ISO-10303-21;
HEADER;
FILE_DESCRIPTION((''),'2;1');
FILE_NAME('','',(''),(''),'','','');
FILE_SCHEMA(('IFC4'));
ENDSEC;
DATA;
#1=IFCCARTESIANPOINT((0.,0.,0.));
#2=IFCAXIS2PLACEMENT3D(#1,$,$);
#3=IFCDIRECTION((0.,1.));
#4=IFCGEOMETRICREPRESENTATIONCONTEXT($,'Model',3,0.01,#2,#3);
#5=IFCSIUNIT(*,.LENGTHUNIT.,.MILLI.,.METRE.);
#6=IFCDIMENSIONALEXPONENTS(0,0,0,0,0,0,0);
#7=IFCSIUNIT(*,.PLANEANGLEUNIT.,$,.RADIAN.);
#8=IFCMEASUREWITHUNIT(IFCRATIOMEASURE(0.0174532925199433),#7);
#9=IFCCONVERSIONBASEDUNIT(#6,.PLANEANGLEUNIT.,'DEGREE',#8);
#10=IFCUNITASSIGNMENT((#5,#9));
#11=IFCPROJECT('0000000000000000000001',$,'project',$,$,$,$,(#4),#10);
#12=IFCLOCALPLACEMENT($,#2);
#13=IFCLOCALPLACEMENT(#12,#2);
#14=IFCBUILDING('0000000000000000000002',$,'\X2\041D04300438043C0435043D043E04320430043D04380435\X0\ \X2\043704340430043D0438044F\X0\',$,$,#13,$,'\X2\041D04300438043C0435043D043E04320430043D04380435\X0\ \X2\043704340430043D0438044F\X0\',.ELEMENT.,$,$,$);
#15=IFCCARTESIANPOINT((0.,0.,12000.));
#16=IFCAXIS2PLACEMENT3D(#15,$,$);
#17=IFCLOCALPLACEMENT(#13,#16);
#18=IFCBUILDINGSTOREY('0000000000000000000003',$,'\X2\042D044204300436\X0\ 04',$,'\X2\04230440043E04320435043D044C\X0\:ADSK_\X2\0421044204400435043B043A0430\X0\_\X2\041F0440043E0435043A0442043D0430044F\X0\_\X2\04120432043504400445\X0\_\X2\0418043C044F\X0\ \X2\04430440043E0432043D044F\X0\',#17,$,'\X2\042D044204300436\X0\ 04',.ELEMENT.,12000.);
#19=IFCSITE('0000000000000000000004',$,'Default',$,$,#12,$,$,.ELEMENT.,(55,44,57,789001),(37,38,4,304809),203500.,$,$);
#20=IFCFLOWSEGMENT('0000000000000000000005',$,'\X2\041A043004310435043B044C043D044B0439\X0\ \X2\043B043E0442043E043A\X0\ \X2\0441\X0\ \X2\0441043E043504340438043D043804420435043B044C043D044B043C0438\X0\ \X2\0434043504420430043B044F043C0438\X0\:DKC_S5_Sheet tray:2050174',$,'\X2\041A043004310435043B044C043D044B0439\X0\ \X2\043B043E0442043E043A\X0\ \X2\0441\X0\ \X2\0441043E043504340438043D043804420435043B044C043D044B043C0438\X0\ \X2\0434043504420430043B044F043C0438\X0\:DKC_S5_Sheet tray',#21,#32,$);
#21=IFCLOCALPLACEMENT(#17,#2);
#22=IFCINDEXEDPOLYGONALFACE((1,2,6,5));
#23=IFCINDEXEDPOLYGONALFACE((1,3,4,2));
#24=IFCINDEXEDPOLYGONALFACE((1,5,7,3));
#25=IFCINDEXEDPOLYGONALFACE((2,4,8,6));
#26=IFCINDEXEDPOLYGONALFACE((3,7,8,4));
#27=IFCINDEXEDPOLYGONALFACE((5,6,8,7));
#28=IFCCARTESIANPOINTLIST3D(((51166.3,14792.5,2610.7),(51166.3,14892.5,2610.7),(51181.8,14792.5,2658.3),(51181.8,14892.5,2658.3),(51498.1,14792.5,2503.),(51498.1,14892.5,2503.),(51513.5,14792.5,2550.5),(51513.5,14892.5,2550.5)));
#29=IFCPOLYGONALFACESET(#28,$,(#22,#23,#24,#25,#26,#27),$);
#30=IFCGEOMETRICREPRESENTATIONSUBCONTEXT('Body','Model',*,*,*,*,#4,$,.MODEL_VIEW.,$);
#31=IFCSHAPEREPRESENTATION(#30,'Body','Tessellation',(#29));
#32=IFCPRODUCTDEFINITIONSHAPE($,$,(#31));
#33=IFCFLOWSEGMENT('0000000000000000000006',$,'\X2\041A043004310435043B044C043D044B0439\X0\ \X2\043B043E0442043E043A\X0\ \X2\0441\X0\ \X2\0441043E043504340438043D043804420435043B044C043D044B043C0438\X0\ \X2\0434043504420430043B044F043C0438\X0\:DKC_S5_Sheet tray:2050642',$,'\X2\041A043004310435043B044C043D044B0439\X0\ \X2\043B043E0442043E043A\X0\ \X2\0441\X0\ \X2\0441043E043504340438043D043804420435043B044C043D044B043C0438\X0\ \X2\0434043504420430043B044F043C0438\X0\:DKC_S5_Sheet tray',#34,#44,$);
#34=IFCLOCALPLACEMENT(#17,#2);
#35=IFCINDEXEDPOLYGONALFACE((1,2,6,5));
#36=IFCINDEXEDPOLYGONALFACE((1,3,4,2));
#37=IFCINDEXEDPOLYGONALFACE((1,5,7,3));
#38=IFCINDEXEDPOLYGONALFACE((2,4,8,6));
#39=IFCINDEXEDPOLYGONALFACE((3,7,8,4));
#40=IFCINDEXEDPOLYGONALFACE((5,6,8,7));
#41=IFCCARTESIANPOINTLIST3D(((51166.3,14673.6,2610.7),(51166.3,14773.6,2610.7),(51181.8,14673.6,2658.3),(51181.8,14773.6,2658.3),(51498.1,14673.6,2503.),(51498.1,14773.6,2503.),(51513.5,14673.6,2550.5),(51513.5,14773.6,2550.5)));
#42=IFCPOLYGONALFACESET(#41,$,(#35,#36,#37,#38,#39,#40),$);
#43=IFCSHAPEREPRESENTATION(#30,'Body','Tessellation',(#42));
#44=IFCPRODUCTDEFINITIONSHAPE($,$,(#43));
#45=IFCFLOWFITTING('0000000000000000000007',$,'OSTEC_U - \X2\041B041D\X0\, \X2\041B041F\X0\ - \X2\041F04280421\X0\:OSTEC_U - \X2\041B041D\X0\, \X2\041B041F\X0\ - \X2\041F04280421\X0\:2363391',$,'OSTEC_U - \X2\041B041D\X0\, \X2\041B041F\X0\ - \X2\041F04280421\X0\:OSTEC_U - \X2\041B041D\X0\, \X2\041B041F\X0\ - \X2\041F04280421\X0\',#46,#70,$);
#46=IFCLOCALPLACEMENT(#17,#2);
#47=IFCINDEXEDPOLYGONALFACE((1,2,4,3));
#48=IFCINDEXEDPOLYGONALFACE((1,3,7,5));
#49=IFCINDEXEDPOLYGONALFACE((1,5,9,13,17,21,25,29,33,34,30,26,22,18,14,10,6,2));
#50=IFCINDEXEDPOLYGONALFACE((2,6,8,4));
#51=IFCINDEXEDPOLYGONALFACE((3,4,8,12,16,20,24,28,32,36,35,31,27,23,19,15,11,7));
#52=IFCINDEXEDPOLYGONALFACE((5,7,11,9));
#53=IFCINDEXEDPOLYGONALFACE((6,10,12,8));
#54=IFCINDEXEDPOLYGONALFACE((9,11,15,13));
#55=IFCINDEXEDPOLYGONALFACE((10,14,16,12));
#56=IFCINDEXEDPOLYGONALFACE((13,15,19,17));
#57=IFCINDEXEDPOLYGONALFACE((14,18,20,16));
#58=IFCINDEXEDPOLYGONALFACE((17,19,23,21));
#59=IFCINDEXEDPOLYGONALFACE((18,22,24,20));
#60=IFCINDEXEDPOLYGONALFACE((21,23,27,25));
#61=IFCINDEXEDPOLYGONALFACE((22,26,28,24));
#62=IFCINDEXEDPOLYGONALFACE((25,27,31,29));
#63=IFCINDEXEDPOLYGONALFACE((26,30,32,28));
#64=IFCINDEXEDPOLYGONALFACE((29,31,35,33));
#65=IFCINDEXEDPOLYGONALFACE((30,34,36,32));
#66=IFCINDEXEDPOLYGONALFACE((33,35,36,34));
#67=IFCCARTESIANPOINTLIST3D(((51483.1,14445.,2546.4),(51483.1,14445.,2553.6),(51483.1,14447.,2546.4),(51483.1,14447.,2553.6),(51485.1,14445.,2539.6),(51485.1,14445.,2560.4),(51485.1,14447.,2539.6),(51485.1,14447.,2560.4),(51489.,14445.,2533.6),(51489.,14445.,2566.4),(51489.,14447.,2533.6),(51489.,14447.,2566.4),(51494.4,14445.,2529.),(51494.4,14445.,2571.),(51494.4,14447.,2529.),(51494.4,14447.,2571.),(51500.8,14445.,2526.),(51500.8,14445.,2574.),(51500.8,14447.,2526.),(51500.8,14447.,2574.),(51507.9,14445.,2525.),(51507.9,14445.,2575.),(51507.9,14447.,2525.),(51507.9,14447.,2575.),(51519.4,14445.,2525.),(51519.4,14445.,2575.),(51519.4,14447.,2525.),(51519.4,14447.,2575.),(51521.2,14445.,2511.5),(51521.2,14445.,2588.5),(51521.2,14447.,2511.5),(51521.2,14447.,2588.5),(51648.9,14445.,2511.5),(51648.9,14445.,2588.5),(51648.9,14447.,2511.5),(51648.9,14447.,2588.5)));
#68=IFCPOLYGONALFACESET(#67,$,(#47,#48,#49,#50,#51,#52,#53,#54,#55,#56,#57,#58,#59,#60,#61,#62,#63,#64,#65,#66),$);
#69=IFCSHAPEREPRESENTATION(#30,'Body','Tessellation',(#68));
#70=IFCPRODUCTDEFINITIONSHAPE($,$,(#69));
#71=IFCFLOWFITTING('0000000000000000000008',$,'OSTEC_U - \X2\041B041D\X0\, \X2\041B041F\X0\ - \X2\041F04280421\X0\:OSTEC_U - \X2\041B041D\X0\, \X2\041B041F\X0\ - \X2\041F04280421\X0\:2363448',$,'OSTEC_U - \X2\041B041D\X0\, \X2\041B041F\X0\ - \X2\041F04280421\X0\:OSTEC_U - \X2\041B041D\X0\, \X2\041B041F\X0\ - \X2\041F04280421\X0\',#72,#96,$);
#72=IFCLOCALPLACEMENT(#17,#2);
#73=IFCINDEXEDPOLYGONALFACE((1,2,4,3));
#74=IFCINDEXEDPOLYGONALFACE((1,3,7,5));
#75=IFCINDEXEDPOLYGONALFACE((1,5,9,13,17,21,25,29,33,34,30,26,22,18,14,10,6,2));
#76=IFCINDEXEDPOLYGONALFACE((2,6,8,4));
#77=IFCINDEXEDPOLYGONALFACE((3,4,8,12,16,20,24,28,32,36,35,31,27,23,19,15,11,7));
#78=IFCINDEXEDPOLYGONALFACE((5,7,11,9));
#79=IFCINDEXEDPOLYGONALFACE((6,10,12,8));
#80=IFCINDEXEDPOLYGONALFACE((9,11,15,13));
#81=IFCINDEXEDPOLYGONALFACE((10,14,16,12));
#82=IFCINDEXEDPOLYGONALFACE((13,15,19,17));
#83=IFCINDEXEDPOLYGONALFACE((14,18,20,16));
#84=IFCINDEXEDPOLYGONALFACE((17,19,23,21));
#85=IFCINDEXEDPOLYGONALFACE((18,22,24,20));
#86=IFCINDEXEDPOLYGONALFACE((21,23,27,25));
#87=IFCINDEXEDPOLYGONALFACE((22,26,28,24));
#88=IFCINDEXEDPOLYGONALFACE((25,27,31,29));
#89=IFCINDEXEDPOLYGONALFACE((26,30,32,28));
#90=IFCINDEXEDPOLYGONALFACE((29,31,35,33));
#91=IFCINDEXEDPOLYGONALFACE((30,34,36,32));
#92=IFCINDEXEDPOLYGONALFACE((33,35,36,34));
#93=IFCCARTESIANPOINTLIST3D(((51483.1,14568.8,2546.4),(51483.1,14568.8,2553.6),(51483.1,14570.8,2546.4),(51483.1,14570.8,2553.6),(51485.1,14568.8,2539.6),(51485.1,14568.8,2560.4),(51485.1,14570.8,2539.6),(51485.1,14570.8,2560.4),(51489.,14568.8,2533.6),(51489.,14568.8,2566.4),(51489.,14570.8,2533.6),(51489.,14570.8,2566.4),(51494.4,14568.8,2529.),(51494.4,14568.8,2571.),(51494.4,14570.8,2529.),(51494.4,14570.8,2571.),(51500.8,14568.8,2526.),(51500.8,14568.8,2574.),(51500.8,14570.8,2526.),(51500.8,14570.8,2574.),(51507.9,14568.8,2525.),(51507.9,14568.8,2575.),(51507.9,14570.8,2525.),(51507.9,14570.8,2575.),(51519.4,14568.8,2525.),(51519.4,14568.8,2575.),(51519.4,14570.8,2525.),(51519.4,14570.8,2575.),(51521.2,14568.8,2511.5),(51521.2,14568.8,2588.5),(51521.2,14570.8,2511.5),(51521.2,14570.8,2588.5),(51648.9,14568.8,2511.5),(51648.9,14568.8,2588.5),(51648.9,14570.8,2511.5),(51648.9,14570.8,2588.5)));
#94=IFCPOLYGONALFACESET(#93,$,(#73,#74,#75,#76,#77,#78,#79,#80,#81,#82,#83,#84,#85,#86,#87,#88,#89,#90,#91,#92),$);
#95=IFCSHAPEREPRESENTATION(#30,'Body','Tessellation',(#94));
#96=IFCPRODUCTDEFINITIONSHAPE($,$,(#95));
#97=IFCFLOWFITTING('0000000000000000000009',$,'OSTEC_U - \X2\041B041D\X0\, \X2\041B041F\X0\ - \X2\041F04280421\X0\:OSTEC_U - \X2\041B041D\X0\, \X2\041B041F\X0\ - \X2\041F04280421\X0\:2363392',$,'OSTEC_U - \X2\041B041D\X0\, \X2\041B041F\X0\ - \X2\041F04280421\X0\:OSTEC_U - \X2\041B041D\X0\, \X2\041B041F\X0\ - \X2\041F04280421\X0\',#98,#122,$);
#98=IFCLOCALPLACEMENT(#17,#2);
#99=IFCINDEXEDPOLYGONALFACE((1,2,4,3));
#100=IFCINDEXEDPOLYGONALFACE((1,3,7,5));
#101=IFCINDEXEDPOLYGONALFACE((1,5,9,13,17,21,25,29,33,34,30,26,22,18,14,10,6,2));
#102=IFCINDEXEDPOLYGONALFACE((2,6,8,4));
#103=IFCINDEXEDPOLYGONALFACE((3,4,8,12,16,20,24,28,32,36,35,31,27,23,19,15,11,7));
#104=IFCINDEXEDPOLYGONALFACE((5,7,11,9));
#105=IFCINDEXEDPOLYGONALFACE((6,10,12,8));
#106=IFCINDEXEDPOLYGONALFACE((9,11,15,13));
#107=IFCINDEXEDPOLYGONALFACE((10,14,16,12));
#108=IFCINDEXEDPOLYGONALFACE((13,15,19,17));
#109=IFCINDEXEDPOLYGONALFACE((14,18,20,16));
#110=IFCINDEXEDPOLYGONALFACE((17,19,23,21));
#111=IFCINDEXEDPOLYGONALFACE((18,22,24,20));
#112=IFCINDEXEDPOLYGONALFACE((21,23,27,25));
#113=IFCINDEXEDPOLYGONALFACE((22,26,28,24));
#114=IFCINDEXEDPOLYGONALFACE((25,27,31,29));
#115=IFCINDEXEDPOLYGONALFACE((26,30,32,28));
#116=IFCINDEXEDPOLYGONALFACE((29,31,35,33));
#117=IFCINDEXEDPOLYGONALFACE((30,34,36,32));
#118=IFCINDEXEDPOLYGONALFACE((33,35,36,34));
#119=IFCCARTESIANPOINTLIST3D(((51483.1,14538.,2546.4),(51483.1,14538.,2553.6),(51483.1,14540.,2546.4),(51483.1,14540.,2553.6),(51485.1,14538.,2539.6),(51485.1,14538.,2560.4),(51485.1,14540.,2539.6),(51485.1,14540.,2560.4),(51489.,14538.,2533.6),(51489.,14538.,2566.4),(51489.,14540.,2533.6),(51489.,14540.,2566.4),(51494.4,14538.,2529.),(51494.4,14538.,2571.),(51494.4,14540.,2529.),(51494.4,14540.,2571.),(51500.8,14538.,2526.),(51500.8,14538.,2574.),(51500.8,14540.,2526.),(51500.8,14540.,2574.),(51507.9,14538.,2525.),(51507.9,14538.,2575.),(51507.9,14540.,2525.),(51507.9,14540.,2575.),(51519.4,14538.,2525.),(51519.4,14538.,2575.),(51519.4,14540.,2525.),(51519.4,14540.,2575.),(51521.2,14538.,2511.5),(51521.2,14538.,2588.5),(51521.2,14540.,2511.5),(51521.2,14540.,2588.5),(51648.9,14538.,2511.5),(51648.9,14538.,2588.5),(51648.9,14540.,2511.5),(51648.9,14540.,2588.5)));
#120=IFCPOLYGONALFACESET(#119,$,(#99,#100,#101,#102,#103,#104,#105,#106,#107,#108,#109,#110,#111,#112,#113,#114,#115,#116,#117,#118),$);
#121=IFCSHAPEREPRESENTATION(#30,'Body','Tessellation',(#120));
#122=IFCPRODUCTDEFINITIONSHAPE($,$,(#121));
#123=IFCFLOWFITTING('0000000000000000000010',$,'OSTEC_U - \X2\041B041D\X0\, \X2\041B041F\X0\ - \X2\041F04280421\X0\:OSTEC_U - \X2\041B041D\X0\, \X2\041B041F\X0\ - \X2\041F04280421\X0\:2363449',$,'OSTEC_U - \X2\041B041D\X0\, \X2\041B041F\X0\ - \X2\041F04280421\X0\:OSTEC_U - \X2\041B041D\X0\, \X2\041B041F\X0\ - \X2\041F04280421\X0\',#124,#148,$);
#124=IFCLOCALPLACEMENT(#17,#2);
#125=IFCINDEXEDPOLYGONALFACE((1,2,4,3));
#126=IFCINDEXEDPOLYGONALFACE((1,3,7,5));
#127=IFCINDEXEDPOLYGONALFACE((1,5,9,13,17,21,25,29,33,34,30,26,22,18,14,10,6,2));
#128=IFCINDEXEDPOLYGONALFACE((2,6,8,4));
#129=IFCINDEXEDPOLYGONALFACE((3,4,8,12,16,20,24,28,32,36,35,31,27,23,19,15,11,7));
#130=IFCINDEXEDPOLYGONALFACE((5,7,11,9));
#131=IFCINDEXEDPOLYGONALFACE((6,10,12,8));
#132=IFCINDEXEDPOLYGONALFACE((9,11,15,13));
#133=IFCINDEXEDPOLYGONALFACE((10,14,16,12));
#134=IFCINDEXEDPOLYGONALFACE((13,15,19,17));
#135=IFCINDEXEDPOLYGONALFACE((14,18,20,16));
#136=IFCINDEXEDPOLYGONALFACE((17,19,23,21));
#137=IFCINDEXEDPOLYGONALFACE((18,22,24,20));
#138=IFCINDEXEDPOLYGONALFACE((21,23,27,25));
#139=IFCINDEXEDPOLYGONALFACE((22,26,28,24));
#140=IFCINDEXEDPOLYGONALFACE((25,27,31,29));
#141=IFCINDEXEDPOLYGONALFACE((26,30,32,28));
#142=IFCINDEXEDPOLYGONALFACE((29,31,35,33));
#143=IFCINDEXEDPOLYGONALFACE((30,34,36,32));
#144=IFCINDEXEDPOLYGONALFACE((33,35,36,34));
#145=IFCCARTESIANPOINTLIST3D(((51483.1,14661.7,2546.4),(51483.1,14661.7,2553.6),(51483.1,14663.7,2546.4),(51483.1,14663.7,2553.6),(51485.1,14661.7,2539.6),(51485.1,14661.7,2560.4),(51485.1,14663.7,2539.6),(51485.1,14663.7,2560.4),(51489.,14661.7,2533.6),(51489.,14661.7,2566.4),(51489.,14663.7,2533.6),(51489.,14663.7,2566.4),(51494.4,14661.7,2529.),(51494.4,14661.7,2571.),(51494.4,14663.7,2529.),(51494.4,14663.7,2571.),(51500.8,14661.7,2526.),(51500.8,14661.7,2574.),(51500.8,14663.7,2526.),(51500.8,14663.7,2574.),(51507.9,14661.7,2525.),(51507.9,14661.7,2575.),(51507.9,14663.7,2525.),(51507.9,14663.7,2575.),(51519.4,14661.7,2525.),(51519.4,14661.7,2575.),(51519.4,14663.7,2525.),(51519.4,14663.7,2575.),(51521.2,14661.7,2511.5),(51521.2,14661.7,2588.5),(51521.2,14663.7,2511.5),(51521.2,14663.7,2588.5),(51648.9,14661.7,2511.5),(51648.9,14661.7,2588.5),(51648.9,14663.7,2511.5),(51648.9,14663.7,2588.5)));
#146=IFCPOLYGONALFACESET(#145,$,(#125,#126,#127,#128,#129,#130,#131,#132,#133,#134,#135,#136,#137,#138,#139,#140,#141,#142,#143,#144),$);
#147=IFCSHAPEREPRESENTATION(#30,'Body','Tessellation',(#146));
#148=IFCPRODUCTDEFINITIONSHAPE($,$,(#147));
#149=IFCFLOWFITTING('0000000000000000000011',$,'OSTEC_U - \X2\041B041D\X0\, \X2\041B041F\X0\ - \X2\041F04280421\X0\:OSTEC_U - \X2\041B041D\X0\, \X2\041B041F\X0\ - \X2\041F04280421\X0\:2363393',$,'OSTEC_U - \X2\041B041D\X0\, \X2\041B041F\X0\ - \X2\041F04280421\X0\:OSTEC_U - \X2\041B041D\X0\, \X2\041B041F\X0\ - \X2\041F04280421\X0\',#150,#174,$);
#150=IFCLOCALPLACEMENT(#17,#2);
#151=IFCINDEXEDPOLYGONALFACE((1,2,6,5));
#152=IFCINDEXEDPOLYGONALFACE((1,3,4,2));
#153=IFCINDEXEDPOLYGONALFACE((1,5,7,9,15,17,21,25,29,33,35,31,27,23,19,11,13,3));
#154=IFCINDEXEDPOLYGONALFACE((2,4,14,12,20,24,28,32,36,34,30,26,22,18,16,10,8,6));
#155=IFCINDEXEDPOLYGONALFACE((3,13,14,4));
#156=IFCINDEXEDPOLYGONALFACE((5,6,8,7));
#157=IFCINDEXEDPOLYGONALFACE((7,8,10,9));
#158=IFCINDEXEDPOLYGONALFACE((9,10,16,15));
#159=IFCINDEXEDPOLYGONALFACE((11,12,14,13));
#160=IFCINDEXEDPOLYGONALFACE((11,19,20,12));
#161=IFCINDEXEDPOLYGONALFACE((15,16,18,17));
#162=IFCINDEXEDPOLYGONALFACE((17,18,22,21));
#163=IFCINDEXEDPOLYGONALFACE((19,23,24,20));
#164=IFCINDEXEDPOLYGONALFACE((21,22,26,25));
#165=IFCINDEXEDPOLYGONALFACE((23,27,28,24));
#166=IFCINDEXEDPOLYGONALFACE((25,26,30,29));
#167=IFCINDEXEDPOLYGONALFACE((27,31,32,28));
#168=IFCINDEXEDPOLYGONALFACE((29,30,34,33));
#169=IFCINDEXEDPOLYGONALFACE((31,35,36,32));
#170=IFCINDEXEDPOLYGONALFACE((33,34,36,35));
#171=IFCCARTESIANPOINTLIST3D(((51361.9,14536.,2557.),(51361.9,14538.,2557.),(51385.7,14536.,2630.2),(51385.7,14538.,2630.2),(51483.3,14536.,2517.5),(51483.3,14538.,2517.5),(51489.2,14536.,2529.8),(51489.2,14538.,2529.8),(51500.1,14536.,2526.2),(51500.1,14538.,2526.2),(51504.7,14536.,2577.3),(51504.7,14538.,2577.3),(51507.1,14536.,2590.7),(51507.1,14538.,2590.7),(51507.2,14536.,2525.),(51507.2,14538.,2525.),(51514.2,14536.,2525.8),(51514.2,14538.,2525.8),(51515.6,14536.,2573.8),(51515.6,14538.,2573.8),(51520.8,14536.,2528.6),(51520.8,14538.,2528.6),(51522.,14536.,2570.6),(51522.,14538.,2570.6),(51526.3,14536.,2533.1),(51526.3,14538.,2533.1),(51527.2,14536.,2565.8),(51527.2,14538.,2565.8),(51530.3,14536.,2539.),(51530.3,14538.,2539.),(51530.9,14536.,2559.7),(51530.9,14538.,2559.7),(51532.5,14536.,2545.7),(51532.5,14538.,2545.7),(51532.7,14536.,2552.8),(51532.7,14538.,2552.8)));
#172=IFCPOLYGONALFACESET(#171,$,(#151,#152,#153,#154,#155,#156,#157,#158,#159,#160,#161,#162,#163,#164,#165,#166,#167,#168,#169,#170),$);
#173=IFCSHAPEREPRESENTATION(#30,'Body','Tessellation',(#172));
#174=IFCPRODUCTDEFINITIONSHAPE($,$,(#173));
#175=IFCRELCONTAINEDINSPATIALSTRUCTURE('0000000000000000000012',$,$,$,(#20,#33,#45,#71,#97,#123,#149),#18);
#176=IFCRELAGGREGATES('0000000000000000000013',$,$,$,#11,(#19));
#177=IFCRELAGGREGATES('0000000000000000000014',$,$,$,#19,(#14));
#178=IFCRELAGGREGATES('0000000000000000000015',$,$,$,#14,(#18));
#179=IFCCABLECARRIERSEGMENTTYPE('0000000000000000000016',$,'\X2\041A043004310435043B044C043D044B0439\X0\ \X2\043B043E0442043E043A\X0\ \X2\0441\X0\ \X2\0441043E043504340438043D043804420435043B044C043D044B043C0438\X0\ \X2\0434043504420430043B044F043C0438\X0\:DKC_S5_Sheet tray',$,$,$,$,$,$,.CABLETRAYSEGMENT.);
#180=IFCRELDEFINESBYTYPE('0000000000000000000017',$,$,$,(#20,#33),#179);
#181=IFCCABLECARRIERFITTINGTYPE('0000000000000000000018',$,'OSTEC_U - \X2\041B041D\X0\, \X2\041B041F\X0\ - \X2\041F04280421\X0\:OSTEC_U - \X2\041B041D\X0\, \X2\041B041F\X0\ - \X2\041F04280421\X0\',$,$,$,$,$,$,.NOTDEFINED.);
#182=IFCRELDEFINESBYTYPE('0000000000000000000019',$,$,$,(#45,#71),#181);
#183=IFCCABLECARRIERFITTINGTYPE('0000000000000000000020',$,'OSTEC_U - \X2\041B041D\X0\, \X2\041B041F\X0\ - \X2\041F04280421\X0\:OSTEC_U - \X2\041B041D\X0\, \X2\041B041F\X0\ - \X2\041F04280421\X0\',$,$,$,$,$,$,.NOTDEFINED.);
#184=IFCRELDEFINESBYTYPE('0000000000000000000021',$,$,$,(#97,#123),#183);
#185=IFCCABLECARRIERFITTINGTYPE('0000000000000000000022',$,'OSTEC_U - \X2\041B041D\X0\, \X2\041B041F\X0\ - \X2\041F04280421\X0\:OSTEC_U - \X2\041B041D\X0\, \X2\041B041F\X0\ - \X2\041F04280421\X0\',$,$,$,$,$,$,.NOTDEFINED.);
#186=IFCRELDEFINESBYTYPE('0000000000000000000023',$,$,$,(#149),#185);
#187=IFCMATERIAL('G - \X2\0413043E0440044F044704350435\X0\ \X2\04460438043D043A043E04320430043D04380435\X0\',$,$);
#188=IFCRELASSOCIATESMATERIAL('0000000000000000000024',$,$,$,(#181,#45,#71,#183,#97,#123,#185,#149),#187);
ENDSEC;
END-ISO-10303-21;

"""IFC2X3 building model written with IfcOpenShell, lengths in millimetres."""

from ifc_helpers import new_model, entity, si_unit, converted_unit, direction, frame, frame_2d, origin, origin_2d_with_axis, place, context, subcontext, project, spatial, polyline, circle_curve, parameter, trimmed, segment, composite_curve, rectangle, outline, extrude, source, transform, mapped, material, type_object, type_shapes, element, save


model = new_model("IFC2X3")

# Units and contexts
model_context = context("Model", 3, precision=0.01, world=origin(), true_north=direction((0.0, 1.0)))
body_context = subcontext(model_context, "Body", "Model", "MODEL_VIEW")
ifc_project = project(units=[si_unit("LENGTHUNIT", "METRE", prefix="MILLI"), converted_unit("PLANEANGLEUNIT", "DEGREE", entity("IfcRatioMeasure", 0.0174532925199433), si_unit("PLANEANGLEUNIT", "RADIAN"), dimensions=[0, 0, 0, 0, 0, 0, 0])], contexts=[model_context])

# Site, building, storey
site_placement = place(None, frame((0.0, 0.0, 0.0)))
site = spatial("IfcSite", under=ifc_project, at=site_placement, Name="Default", CompositionType="ELEMENT", RefLatitude=(55, 44, 57, 789001), RefLongitude=(37, 38, 4, 304809), RefElevation=203500.0)
building_placement = place(site_placement, origin())
building = spatial("IfcBuilding", under=site, at=building_placement, Name="Наименование здания", LongName="Наименование здания", CompositionType="ELEMENT")
storey_placement = place(building_placement, frame((0.0, 0.0, 12000.0)))
storey = spatial("IfcBuildingStorey", under=building, at=storey_placement, Name="Этаж 04", ObjectType="Уровень:ADSK_Стрелка_Проектная_Вверх_Имя уровня", LongName="Этаж 04", CompositionType="ELEMENT", Elevation=12000.0)

# Flow segments
cable_carrier_segment_type = type_object("IfcCableCarrierSegmentType", Name="Кабельный лоток с соединительными деталями:DKC_S5_Sheet tray", PredefinedType="CABLETRAYSEGMENT")
flow_segment_1_placement = place(storey_placement, frame((51166.3, 14792.5, 2503.0)))
element("IfcFlowSegment", 1, at=flow_segment_1_placement, inside=storey, type_object=cable_carrier_segment_type, Name="Кабельный лоток с соединительными деталями:DKC_S5_Sheet tray:2050174", ObjectType="Кабельный лоток с соединительными деталями:DKC_S5_Sheet tray", context=body_context, shape_type="SweptSolid", body=[
    extrude(rectangle(XDim=50.0, YDim=100.0, at=origin_2d_with_axis()), frame((7.7, 50.0, 131.6), z_axis=(0.951057, 0.0, -0.309017), x_axis=(0.309017, 0.0, 0.951057)), (0.0, 0.0, 1.0), 348.8),
])
flow_segment_2_placement = place(storey_placement, frame((51166.3, 14673.6, 2503.0)))
element("IfcFlowSegment", 2, at=flow_segment_2_placement, inside=storey, type_object=cable_carrier_segment_type, Name="Кабельный лоток с соединительными деталями:DKC_S5_Sheet tray:2050642", ObjectType="Кабельный лоток с соединительными деталями:DKC_S5_Sheet tray", context=body_context, shape_type="SweptSolid", body=[
    extrude(rectangle(XDim=50.0, YDim=100.0, at=frame_2d((0.0, 0.0), x_axis=(1.0, 0.0))), frame((7.7, 50.0, 131.6), z_axis=(0.951057, 0.0, -0.309017), x_axis=(0.309017, 0.0, 0.951057)), (0.0, 0.0, 1.0), 348.8),
])

# Flow fittings
ifc_material = material(Name="G - Горячее цинкование")
cable_carrier_fitting_type_1 = type_object("IfcCableCarrierFittingType", Name="OSTEC_U - ЛН, ЛП - ПШС:OSTEC_U - ЛН, ЛП - ПШС", PredefinedType="NOTDEFINED", material=ifc_material)
shared_shape_1 = source(origin(), body_context, "Body", "SweptSolid", [
    extrude(outline(composite_curve([segment(trimmed(circle_curve(frame_2d((-41.5, 0.0), x_axis=(1.0, 0.0)), 25.0), [parameter(90.0)], [parameter(270.0)], True, "PARAMETER"), True, "CONTINUOUS"), segment(polyline([(-41.5, -25.0), (-30.0, -25.0)]), True, "CONTINUOUS"), segment(polyline([(-30.0, -25.0), (-28.1, -38.5)]), True, "CONTINUOUS"), segment(polyline([(-28.1, -38.5), (99.5, -38.5)]), True, "CONTINUOUS"), segment(polyline([(99.5, -38.5), (99.5, 38.5)]), True, "CONTINUOUS"), segment(polyline([(99.5, 38.5), (-28.1, 38.5)]), True, "CONTINUOUS"), segment(polyline([(-28.1, 38.5), (-30.0, 25.0)]), True, "CONTINUOUS"), segment(polyline([(-30.0, 25.0), (-41.5, 25.0)]), True, "CONTINUOUS")], self_intersect=False)), frame((41.5, 0.0, 0.0), z_axis=(0.0, 0.0, -1.0), x_axis=(1.0, 0.0, 0.0)), (0.0, 0.0, -1.0), 2.0),
])
type_shapes(cable_carrier_fitting_type_1, [shared_shape_1])
for number, where, z_axis, x_axis, name in (
    (3, (51507.9, 14447.0, 2550.0), (0.0, -1.0, 0.0), (1.0, 0.0, 0.0), "OSTEC_U - ЛН, ЛП - ПШС:OSTEC_U - ЛН, ЛП - ПШС:2363391"),
    (4, (51507.9, 14570.8, 2550.0), (0.0, -1.0, 0.0), (1.0, 0.0, 0.0), "OSTEC_U - ЛН, ЛП - ПШС:OSTEC_U - ЛН, ЛП - ПШС:2363448"),
):
    element("IfcFlowFitting", number, at=place(storey_placement, frame(where, z_axis=z_axis, x_axis=x_axis)), inside=storey, type_object=cable_carrier_fitting_type_1, material=ifc_material, Name=name, ObjectType="OSTEC_U - ЛН, ЛП - ПШС:OSTEC_U - ЛН, ЛП - ПШС", context=body_context, shape_type="MappedRepresentation", body=[
        mapped(shared_shape_1, transform((0.0, 0.0, 0.0), scale=1.0)),
    ])
cable_carrier_fitting_type_2 = type_object("IfcCableCarrierFittingType", Name="OSTEC_U - ЛН, ЛП - ПШС:OSTEC_U - ЛН, ЛП - ПШС", PredefinedType="NOTDEFINED", material=ifc_material)
shared_shape_2 = source(origin(), body_context, "Body", "SweptSolid", [
    extrude(outline(composite_curve([segment(trimmed(circle_curve(frame_2d((-41.5, 0.0), x_axis=(1.0, 0.0)), 25.0), [parameter(90.0)], [parameter(270.0)], True, "PARAMETER"), True, "CONTINUOUS"), segment(polyline([(-41.5, -25.0), (-30.0, -25.0)]), True, "CONTINUOUS"), segment(polyline([(-30.0, -25.0), (-28.1, -38.5)]), True, "CONTINUOUS"), segment(polyline([(-28.1, -38.5), (99.5, -38.5)]), True, "CONTINUOUS"), segment(polyline([(99.5, -38.5), (99.5, 38.5)]), True, "CONTINUOUS"), segment(polyline([(99.5, 38.5), (-28.1, 38.5)]), True, "CONTINUOUS"), segment(polyline([(-28.1, 38.5), (-30.0, 25.0)]), True, "CONTINUOUS"), segment(polyline([(-30.0, 25.0), (-41.5, 25.0)]), True, "CONTINUOUS")], self_intersect=False)), frame((41.5, 0.0, 0.0)), (0.0, 0.0, 1.0), 2.0),
])
type_shapes(cable_carrier_fitting_type_2, [shared_shape_2])
for number, where, z_axis, x_axis, name in (
    (5, (51507.9, 14538.0, 2550.0), (0.0, 1.0, 0.0), (1.0, 0.0, 0.0), "OSTEC_U - ЛН, ЛП - ПШС:OSTEC_U - ЛН, ЛП - ПШС:2363392"),
    (6, (51507.9, 14661.7, 2550.0), (0.0, 1.0, 0.0), (1.0, 0.0, 0.0), "OSTEC_U - ЛН, ЛП - ПШС:OSTEC_U - ЛН, ЛП - ПШС:2363449"),
):
    element("IfcFlowFitting", number, at=place(storey_placement, frame(where, z_axis=z_axis, x_axis=x_axis)), inside=storey, type_object=cable_carrier_fitting_type_2, material=ifc_material, Name=name, ObjectType="OSTEC_U - ЛН, ЛП - ПШС:OSTEC_U - ЛН, ЛП - ПШС", context=body_context, shape_type="MappedRepresentation", body=[
        mapped(shared_shape_2, transform((0.0, 0.0, 0.0), scale=1.0)),
    ])
cable_carrier_fitting_type_3 = type_object("IfcCableCarrierFittingType", Name="OSTEC_U - ЛН, ЛП - ПШС:OSTEC_U - ЛН, ЛП - ПШС", PredefinedType="NOTDEFINED", material=ifc_material)
shared_shape_3 = source(origin(), body_context, "Body", "SweptSolid", [
    extrude(outline(composite_curve([segment(trimmed(circle_curve(frame_2d((-41.5, 0.0), x_axis=(1.0, 0.0)), 25.0), [parameter(90.0)], [parameter(270.0)], True, "PARAMETER"), True, "CONTINUOUS"), segment(polyline([(-41.5, -25.0), (-30.0, -25.0)]), True, "CONTINUOUS"), segment(polyline([(-30.0, -25.0), (-28.1, -38.5)]), True, "CONTINUOUS"), segment(polyline([(-28.1, -38.5), (99.5, -38.5)]), True, "CONTINUOUS"), segment(polyline([(99.5, -38.5), (99.5, 38.5)]), True, "CONTINUOUS"), segment(polyline([(99.5, 38.5), (-28.1, 38.5)]), True, "CONTINUOUS"), segment(polyline([(-28.1, 38.5), (-30.0, 25.0)]), True, "CONTINUOUS"), segment(polyline([(-30.0, 25.0), (-41.5, 25.0)]), True, "CONTINUOUS")], self_intersect=False)), frame((41.5, 0.0, 0.0), z_axis=(0.0, 0.0, -1.0), x_axis=(1.0, 0.0, 0.0)), (0.0, 0.0, -1.0), 2.0),
])
type_shapes(cable_carrier_fitting_type_3, [shared_shape_3])
for number, where, z_axis, x_axis, name in (
    (7, (51507.9, 14536.0, 2550.0), (0.0, 1.0, 0.0), (-0.951057, 0.0, 0.309017), "OSTEC_U - ЛН, ЛП - ПШС:OSTEC_U - ЛН, ЛП - ПШС:2363393"),
):
    element("IfcFlowFitting", number, at=place(storey_placement, frame(where, z_axis=z_axis, x_axis=x_axis)), inside=storey, type_object=cable_carrier_fitting_type_3, material=ifc_material, Name=name, ObjectType="OSTEC_U - ЛН, ЛП - ПШС:OSTEC_U - ЛН, ЛП - ПШС", context=body_context, shape_type="MappedRepresentation", body=[
        mapped(shared_shape_3, transform((0.0, 0.0, 0.0), scale=1.0)),
    ])

save(model, "model.ifc")
